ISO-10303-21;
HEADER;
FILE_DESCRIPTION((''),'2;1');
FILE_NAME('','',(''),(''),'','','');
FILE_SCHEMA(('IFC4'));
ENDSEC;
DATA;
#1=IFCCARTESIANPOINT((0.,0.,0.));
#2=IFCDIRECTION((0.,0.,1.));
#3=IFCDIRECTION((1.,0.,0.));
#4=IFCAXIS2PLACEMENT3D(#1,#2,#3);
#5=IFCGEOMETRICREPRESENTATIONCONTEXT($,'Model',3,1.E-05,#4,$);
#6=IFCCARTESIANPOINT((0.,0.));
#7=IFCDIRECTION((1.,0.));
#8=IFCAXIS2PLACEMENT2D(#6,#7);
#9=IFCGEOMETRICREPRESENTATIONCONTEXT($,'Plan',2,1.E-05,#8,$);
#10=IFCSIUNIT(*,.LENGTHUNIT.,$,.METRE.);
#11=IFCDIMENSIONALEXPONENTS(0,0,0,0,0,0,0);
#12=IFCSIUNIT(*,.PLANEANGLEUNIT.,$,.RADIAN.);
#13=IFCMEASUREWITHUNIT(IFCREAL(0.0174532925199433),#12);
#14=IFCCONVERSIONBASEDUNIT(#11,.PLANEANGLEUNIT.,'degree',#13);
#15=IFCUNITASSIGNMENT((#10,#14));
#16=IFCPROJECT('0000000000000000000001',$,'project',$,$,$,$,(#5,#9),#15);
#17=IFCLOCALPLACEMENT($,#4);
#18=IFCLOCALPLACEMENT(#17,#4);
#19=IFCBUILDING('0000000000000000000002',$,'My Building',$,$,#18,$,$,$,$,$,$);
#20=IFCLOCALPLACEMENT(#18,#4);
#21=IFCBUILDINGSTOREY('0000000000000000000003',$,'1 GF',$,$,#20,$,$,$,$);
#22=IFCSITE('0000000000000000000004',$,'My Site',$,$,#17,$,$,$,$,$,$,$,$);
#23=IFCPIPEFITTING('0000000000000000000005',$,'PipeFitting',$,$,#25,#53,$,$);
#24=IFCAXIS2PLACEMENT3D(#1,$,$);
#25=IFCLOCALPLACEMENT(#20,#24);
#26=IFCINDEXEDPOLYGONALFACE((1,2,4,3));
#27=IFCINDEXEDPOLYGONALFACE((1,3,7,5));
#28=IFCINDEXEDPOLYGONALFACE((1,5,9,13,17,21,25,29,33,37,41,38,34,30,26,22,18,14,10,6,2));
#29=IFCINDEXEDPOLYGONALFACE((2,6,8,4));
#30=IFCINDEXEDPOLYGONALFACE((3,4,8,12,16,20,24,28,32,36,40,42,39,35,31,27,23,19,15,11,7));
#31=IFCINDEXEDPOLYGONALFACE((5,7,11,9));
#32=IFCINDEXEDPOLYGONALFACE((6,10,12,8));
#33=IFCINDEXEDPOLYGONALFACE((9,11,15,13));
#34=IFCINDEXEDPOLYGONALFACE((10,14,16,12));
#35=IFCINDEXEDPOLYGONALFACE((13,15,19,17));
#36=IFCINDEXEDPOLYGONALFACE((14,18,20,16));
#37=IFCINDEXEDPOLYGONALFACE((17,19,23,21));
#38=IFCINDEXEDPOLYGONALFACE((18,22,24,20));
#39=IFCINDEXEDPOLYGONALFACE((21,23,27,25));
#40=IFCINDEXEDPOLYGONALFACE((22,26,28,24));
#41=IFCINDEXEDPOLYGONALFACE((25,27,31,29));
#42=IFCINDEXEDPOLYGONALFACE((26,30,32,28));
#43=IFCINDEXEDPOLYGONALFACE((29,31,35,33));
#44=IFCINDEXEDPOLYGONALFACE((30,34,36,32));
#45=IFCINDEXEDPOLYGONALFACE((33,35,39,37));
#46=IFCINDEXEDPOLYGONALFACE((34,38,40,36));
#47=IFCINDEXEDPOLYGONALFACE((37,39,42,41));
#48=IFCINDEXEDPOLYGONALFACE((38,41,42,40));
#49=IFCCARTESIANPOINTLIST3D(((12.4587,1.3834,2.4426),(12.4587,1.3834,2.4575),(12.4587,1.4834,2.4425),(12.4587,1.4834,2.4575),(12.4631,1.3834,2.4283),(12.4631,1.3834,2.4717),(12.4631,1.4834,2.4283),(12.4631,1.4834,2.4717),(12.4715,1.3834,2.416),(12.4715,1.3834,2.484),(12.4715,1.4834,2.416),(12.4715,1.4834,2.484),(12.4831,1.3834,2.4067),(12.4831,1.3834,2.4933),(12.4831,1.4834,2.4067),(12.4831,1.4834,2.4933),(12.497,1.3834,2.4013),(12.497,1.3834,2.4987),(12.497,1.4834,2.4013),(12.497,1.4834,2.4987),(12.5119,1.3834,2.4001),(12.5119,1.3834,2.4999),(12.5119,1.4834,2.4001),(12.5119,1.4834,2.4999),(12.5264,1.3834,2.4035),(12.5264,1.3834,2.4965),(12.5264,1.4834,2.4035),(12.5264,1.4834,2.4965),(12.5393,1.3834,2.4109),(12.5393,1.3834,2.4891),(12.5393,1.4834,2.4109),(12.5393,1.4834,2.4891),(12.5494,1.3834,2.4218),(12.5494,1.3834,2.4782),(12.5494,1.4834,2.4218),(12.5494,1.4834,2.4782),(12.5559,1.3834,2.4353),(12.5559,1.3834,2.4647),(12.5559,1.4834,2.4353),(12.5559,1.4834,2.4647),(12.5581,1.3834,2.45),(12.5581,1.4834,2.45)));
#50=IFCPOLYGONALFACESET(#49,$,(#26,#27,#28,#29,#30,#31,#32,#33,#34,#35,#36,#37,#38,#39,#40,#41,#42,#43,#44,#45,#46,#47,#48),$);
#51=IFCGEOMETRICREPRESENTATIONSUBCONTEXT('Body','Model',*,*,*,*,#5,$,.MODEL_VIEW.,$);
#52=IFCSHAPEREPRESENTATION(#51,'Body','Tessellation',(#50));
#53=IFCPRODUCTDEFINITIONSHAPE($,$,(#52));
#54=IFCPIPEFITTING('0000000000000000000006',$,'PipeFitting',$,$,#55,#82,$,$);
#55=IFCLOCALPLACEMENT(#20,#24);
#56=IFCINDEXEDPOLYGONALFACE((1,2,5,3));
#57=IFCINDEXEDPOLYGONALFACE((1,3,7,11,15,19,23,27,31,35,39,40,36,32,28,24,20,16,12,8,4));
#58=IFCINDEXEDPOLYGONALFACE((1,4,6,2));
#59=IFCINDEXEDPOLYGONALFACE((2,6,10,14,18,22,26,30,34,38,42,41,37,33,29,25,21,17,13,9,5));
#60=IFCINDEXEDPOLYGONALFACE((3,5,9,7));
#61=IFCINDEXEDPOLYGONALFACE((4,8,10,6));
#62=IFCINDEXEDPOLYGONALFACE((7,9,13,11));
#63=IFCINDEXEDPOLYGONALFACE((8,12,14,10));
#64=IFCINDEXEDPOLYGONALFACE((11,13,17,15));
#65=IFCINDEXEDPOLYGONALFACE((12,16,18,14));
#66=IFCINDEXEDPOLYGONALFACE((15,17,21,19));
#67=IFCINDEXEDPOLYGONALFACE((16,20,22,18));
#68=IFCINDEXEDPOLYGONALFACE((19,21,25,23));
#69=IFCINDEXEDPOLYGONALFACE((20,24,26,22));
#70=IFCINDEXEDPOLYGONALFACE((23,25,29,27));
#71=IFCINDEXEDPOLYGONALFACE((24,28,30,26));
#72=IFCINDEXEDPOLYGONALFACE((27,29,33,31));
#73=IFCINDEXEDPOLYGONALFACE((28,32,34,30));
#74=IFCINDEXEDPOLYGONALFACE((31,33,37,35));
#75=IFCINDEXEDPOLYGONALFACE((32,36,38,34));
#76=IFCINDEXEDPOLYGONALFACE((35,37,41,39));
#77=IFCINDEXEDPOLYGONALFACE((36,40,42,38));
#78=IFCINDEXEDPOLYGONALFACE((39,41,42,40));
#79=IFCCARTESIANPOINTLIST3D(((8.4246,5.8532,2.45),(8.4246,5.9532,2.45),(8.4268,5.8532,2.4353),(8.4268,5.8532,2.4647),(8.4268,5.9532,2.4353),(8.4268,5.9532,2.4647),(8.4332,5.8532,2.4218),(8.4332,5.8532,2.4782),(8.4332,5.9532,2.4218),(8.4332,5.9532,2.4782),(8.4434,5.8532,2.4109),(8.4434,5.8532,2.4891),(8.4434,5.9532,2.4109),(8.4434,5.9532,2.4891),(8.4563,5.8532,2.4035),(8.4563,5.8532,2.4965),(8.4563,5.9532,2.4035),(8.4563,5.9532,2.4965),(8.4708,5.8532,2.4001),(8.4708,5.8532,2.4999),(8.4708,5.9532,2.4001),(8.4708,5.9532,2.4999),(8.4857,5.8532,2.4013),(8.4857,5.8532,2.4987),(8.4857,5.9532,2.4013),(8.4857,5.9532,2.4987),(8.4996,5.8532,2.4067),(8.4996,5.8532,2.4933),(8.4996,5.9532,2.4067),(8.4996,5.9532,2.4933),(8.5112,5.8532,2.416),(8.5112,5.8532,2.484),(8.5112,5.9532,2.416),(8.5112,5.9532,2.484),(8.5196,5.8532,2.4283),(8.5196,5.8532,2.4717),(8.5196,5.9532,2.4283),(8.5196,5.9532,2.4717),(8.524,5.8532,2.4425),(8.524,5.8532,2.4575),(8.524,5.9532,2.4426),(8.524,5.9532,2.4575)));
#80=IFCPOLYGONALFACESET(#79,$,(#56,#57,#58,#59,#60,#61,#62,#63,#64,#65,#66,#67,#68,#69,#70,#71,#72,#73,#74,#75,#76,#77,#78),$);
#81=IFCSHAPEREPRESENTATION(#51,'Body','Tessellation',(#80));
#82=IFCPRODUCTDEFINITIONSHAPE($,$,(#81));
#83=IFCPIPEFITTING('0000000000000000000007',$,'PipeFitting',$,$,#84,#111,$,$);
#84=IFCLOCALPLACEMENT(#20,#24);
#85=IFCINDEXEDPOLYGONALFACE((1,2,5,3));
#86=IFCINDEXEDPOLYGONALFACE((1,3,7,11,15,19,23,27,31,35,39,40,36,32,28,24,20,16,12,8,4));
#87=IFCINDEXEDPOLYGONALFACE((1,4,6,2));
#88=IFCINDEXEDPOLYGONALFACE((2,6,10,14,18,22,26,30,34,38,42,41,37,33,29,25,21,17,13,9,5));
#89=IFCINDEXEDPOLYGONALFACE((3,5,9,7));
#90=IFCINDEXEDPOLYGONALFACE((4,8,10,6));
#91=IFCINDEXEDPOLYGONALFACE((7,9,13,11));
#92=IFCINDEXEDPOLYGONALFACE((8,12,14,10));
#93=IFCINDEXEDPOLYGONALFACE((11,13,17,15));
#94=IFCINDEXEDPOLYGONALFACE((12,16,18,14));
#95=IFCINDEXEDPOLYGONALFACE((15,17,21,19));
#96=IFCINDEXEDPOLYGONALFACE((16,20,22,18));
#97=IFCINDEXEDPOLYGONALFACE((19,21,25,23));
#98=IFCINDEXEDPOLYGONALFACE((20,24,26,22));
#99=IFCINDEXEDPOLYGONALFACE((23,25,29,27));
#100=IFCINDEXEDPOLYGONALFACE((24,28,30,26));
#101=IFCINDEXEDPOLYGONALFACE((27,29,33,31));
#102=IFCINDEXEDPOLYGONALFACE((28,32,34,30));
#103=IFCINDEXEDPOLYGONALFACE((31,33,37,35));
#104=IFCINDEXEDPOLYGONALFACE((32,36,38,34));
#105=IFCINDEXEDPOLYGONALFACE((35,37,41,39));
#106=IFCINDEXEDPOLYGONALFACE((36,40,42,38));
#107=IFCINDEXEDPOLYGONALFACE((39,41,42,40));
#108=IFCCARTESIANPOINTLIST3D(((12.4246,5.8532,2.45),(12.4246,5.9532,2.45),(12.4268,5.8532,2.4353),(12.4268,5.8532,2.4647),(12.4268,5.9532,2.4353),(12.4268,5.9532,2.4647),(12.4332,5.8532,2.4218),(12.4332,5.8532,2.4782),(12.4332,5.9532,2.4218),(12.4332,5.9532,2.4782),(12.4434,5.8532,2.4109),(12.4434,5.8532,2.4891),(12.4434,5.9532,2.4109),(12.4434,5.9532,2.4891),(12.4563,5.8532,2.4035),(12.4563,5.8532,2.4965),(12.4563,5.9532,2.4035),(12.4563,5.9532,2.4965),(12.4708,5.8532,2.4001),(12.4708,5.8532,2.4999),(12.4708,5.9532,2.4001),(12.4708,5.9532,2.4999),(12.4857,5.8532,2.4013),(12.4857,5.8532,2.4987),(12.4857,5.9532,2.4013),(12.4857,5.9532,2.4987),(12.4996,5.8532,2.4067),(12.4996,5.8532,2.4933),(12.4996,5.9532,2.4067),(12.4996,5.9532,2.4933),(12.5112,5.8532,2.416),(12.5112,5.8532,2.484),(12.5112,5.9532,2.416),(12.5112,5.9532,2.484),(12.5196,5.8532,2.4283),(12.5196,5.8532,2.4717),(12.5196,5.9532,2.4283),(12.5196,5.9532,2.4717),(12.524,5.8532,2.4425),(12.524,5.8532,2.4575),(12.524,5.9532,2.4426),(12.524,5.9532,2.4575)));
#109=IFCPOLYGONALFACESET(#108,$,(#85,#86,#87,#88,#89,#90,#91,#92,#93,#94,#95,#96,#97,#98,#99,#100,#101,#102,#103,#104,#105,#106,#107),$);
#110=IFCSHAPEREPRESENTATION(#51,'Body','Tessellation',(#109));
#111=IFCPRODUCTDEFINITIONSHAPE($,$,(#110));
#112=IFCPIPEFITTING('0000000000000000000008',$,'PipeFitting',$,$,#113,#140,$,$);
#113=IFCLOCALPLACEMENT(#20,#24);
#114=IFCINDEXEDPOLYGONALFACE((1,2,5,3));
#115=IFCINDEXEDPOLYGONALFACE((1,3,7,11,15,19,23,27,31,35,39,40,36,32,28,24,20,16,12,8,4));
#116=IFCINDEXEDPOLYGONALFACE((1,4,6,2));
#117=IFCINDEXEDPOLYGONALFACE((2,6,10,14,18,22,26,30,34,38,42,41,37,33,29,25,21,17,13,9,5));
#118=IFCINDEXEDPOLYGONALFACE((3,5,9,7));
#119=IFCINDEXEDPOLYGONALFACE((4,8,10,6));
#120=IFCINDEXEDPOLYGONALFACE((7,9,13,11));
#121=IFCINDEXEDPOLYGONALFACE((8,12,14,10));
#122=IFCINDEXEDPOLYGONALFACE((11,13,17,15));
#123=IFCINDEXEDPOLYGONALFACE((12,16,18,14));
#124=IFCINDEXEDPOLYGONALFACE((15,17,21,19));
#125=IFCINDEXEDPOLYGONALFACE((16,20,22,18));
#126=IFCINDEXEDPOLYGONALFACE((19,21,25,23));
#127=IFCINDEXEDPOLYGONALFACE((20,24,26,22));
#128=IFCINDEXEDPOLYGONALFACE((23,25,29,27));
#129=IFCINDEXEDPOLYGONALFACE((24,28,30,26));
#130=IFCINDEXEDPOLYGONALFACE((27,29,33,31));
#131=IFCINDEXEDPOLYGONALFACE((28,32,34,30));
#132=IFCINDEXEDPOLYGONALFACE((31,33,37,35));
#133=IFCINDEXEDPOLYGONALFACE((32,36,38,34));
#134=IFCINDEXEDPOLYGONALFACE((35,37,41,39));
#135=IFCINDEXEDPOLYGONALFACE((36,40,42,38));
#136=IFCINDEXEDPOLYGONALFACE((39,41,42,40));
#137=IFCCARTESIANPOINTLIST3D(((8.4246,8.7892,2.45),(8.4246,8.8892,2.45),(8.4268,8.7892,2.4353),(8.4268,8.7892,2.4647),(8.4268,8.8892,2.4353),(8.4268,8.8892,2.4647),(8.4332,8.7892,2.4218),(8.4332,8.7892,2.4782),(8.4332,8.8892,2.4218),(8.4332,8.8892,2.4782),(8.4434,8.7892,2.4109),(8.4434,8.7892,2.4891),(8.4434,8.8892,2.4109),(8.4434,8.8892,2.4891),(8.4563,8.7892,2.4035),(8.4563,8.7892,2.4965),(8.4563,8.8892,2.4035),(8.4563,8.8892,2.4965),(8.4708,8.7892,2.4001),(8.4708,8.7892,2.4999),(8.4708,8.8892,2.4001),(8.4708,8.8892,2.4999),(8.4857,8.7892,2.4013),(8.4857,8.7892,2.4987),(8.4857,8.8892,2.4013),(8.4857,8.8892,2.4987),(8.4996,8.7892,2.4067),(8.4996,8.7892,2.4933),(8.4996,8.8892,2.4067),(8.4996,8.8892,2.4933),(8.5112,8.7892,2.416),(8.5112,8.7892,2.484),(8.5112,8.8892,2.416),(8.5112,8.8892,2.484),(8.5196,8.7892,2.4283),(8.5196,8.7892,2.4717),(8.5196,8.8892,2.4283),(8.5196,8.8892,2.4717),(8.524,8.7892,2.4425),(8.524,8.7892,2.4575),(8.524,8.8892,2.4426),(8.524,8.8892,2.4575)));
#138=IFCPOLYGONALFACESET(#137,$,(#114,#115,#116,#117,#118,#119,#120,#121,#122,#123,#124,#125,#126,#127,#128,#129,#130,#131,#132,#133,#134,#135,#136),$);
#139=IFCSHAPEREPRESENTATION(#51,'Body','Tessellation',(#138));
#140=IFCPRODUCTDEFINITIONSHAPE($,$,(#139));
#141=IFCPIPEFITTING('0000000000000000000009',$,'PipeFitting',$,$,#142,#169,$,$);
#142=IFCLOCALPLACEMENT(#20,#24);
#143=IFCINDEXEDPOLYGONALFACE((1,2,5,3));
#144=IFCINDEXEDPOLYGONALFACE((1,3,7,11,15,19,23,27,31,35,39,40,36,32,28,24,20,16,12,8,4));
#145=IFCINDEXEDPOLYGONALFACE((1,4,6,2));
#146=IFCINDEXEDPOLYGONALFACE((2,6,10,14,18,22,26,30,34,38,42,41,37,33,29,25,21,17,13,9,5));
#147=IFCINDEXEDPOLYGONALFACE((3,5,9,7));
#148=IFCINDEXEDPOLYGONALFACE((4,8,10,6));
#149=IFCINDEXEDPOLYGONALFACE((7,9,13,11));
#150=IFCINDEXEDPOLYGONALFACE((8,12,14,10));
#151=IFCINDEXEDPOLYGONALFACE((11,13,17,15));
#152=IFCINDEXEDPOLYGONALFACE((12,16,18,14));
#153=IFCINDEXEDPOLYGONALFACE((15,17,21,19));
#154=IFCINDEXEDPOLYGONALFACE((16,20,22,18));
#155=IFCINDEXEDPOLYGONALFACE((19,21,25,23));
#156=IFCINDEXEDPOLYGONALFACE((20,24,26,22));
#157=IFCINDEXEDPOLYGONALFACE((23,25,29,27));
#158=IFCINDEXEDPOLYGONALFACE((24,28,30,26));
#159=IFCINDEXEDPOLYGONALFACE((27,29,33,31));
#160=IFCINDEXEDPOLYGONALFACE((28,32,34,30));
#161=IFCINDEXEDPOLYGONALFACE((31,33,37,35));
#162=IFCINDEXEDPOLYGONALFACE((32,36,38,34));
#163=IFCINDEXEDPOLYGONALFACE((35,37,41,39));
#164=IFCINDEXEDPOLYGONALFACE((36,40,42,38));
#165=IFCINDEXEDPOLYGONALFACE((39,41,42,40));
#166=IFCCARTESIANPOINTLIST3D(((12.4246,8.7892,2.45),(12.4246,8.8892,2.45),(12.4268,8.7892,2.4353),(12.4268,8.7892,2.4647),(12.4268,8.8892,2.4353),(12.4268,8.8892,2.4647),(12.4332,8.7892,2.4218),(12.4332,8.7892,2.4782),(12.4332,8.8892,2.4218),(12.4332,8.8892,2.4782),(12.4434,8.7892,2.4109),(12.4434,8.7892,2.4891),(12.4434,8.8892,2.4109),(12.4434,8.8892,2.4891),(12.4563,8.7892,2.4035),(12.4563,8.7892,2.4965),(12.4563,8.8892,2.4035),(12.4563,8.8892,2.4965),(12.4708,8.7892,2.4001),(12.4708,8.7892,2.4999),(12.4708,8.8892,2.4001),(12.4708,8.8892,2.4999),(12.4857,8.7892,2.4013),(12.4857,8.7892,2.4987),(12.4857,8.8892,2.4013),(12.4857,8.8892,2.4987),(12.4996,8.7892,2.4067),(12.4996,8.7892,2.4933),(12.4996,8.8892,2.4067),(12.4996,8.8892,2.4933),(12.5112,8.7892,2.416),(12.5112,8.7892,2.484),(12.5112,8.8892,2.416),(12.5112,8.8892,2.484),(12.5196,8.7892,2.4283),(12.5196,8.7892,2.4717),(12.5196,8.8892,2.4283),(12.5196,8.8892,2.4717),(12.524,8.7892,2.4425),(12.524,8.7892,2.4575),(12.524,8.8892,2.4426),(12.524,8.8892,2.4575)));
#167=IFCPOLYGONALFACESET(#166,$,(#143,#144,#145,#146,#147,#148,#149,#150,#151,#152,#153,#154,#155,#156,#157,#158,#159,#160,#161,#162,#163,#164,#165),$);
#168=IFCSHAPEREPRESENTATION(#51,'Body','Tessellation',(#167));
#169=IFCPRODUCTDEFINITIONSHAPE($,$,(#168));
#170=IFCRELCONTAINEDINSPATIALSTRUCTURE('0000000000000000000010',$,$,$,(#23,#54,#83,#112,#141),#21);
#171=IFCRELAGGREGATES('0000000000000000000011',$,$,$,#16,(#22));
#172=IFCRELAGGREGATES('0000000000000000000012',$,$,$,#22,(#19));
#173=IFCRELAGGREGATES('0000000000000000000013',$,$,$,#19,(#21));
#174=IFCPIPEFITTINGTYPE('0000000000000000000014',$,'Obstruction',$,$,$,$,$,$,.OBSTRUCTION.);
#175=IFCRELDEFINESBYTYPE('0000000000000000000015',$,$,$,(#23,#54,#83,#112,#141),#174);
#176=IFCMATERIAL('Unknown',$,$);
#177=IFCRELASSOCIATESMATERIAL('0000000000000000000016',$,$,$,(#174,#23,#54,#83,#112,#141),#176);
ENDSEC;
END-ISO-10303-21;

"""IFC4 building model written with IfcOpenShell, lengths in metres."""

from ifc_helpers import new_model, entity, si_unit, converted_unit, frame, origin_with_axes, origin_2d_with_axis, place, context, subcontext, project, spatial, circle, extrude, material, material_profile, profile_set, profile_usage, type_object, element, save


model = new_model("IFC4")

# Units and contexts
model_context = context("Model", 3, precision=1e-05, world=origin_with_axes())
plan_context = context("Plan", 2, precision=1e-05, world=origin_2d_with_axis())
body_context = subcontext(model_context, "Body", "Model", "MODEL_VIEW")
ifc_project = project(units=[si_unit("LENGTHUNIT", "METRE"), converted_unit("PLANEANGLEUNIT", "degree", entity("IfcReal", 0.0174532925199433), si_unit("PLANEANGLEUNIT", "RADIAN"), dimensions=[0, 0, 0, 0, 0, 0, 0])], contexts=[model_context, plan_context])

# Site, building, storey
site_placement = place(None, origin_with_axes())
site = spatial("IfcSite", under=ifc_project, at=site_placement, Name="My Site")
building_placement = place(site_placement, origin_with_axes())
building = spatial("IfcBuilding", under=site, at=building_placement, Name="My Building")
storey_placement = place(building_placement, origin_with_axes())
storey = spatial("IfcBuildingStorey", under=building, at=storey_placement, Name="1 GF")

# Shared definitions
ifc_material = material(Name="Unknown")

# Pipe fittings
ifc_material_profile_1 = material_profile(ifc_material, circle(Radius=0.05))
ifc_profile_set_1 = profile_set([ifc_material_profile_1])
pipe_fitting_type = type_object("IfcPipeFittingType", Name="Obstruction", PredefinedType="OBSTRUCTION", material=ifc_profile_set_1)
ifc_profile_usage_1 = profile_usage(ifc_profile_set_1, cardinal=5)
pipe_fitting_1_placement = place(storey_placement, frame((12.5081, 1.4834, 2.45), z_axis=(0.0, -1.0, 0.000025), x_axis=(1.0, 0.0, 0.0)))
element("IfcPipeFitting", 1, at=pipe_fitting_1_placement, inside=storey, type_object=pipe_fitting_type, material=ifc_profile_usage_1, Name="PipeFitting", context=body_context, shape_type="SweptSolid", body=[
    extrude(circle(Radius=0.05), origin_with_axes(), (0.0, 0.0, 1.0), 0.1),
])
ifc_profile_usage_2 = profile_usage(ifc_profile_set_1, cardinal=5)
pipe_fitting_2_placement = place(storey_placement, frame((8.4746, 5.8532, 2.45), z_axis=(0.0, 1.0, 0.000025), x_axis=(-1.0, 0.0, 0.0)))
element("IfcPipeFitting", 2, at=pipe_fitting_2_placement, inside=storey, type_object=pipe_fitting_type, material=ifc_profile_usage_2, Name="PipeFitting", context=body_context, shape_type="SweptSolid", body=[
    extrude(circle(Radius=0.05), origin_with_axes(), (0.0, 0.0, 1.0), 0.1),
])
ifc_profile_usage_3 = profile_usage(ifc_profile_set_1, cardinal=5)
pipe_fitting_3_placement = place(storey_placement, frame((12.4746, 5.8532, 2.45), z_axis=(0.0, 1.0, 0.000025), x_axis=(-1.0, 0.0, 0.0)))
element("IfcPipeFitting", 3, at=pipe_fitting_3_placement, inside=storey, type_object=pipe_fitting_type, material=ifc_profile_usage_3, Name="PipeFitting", context=body_context, shape_type="SweptSolid", body=[
    extrude(circle(Radius=0.05), origin_with_axes(), (0.0, 0.0, 1.0), 0.1),
])
ifc_profile_usage_4 = profile_usage(ifc_profile_set_1, cardinal=5)
pipe_fitting_4_placement = place(storey_placement, frame((8.4746, 8.7892, 2.45), z_axis=(0.0, 1.0, 0.000025), x_axis=(-1.0, 0.0, 0.0)))
element("IfcPipeFitting", 4, at=pipe_fitting_4_placement, inside=storey, type_object=pipe_fitting_type, material=ifc_profile_usage_4, Name="PipeFitting", context=body_context, shape_type="SweptSolid", body=[
    extrude(circle(Radius=0.05), origin_with_axes(), (0.0, 0.0, 1.0), 0.1),
])
ifc_profile_usage_5 = profile_usage(ifc_profile_set_1, cardinal=5)
pipe_fitting_5_placement = place(storey_placement, frame((12.4746, 8.7892, 2.45), z_axis=(0.0, 1.0, 0.000025), x_axis=(-1.0, 0.0, 0.0)))
element("IfcPipeFitting", 5, at=pipe_fitting_5_placement, inside=storey, type_object=pipe_fitting_type, material=ifc_profile_usage_5, Name="PipeFitting", context=body_context, shape_type="SweptSolid", body=[
    extrude(circle(Radius=0.05), origin_with_axes(), (0.0, 0.0, 1.0), 0.1),
])

save(model, "model.ifc")
